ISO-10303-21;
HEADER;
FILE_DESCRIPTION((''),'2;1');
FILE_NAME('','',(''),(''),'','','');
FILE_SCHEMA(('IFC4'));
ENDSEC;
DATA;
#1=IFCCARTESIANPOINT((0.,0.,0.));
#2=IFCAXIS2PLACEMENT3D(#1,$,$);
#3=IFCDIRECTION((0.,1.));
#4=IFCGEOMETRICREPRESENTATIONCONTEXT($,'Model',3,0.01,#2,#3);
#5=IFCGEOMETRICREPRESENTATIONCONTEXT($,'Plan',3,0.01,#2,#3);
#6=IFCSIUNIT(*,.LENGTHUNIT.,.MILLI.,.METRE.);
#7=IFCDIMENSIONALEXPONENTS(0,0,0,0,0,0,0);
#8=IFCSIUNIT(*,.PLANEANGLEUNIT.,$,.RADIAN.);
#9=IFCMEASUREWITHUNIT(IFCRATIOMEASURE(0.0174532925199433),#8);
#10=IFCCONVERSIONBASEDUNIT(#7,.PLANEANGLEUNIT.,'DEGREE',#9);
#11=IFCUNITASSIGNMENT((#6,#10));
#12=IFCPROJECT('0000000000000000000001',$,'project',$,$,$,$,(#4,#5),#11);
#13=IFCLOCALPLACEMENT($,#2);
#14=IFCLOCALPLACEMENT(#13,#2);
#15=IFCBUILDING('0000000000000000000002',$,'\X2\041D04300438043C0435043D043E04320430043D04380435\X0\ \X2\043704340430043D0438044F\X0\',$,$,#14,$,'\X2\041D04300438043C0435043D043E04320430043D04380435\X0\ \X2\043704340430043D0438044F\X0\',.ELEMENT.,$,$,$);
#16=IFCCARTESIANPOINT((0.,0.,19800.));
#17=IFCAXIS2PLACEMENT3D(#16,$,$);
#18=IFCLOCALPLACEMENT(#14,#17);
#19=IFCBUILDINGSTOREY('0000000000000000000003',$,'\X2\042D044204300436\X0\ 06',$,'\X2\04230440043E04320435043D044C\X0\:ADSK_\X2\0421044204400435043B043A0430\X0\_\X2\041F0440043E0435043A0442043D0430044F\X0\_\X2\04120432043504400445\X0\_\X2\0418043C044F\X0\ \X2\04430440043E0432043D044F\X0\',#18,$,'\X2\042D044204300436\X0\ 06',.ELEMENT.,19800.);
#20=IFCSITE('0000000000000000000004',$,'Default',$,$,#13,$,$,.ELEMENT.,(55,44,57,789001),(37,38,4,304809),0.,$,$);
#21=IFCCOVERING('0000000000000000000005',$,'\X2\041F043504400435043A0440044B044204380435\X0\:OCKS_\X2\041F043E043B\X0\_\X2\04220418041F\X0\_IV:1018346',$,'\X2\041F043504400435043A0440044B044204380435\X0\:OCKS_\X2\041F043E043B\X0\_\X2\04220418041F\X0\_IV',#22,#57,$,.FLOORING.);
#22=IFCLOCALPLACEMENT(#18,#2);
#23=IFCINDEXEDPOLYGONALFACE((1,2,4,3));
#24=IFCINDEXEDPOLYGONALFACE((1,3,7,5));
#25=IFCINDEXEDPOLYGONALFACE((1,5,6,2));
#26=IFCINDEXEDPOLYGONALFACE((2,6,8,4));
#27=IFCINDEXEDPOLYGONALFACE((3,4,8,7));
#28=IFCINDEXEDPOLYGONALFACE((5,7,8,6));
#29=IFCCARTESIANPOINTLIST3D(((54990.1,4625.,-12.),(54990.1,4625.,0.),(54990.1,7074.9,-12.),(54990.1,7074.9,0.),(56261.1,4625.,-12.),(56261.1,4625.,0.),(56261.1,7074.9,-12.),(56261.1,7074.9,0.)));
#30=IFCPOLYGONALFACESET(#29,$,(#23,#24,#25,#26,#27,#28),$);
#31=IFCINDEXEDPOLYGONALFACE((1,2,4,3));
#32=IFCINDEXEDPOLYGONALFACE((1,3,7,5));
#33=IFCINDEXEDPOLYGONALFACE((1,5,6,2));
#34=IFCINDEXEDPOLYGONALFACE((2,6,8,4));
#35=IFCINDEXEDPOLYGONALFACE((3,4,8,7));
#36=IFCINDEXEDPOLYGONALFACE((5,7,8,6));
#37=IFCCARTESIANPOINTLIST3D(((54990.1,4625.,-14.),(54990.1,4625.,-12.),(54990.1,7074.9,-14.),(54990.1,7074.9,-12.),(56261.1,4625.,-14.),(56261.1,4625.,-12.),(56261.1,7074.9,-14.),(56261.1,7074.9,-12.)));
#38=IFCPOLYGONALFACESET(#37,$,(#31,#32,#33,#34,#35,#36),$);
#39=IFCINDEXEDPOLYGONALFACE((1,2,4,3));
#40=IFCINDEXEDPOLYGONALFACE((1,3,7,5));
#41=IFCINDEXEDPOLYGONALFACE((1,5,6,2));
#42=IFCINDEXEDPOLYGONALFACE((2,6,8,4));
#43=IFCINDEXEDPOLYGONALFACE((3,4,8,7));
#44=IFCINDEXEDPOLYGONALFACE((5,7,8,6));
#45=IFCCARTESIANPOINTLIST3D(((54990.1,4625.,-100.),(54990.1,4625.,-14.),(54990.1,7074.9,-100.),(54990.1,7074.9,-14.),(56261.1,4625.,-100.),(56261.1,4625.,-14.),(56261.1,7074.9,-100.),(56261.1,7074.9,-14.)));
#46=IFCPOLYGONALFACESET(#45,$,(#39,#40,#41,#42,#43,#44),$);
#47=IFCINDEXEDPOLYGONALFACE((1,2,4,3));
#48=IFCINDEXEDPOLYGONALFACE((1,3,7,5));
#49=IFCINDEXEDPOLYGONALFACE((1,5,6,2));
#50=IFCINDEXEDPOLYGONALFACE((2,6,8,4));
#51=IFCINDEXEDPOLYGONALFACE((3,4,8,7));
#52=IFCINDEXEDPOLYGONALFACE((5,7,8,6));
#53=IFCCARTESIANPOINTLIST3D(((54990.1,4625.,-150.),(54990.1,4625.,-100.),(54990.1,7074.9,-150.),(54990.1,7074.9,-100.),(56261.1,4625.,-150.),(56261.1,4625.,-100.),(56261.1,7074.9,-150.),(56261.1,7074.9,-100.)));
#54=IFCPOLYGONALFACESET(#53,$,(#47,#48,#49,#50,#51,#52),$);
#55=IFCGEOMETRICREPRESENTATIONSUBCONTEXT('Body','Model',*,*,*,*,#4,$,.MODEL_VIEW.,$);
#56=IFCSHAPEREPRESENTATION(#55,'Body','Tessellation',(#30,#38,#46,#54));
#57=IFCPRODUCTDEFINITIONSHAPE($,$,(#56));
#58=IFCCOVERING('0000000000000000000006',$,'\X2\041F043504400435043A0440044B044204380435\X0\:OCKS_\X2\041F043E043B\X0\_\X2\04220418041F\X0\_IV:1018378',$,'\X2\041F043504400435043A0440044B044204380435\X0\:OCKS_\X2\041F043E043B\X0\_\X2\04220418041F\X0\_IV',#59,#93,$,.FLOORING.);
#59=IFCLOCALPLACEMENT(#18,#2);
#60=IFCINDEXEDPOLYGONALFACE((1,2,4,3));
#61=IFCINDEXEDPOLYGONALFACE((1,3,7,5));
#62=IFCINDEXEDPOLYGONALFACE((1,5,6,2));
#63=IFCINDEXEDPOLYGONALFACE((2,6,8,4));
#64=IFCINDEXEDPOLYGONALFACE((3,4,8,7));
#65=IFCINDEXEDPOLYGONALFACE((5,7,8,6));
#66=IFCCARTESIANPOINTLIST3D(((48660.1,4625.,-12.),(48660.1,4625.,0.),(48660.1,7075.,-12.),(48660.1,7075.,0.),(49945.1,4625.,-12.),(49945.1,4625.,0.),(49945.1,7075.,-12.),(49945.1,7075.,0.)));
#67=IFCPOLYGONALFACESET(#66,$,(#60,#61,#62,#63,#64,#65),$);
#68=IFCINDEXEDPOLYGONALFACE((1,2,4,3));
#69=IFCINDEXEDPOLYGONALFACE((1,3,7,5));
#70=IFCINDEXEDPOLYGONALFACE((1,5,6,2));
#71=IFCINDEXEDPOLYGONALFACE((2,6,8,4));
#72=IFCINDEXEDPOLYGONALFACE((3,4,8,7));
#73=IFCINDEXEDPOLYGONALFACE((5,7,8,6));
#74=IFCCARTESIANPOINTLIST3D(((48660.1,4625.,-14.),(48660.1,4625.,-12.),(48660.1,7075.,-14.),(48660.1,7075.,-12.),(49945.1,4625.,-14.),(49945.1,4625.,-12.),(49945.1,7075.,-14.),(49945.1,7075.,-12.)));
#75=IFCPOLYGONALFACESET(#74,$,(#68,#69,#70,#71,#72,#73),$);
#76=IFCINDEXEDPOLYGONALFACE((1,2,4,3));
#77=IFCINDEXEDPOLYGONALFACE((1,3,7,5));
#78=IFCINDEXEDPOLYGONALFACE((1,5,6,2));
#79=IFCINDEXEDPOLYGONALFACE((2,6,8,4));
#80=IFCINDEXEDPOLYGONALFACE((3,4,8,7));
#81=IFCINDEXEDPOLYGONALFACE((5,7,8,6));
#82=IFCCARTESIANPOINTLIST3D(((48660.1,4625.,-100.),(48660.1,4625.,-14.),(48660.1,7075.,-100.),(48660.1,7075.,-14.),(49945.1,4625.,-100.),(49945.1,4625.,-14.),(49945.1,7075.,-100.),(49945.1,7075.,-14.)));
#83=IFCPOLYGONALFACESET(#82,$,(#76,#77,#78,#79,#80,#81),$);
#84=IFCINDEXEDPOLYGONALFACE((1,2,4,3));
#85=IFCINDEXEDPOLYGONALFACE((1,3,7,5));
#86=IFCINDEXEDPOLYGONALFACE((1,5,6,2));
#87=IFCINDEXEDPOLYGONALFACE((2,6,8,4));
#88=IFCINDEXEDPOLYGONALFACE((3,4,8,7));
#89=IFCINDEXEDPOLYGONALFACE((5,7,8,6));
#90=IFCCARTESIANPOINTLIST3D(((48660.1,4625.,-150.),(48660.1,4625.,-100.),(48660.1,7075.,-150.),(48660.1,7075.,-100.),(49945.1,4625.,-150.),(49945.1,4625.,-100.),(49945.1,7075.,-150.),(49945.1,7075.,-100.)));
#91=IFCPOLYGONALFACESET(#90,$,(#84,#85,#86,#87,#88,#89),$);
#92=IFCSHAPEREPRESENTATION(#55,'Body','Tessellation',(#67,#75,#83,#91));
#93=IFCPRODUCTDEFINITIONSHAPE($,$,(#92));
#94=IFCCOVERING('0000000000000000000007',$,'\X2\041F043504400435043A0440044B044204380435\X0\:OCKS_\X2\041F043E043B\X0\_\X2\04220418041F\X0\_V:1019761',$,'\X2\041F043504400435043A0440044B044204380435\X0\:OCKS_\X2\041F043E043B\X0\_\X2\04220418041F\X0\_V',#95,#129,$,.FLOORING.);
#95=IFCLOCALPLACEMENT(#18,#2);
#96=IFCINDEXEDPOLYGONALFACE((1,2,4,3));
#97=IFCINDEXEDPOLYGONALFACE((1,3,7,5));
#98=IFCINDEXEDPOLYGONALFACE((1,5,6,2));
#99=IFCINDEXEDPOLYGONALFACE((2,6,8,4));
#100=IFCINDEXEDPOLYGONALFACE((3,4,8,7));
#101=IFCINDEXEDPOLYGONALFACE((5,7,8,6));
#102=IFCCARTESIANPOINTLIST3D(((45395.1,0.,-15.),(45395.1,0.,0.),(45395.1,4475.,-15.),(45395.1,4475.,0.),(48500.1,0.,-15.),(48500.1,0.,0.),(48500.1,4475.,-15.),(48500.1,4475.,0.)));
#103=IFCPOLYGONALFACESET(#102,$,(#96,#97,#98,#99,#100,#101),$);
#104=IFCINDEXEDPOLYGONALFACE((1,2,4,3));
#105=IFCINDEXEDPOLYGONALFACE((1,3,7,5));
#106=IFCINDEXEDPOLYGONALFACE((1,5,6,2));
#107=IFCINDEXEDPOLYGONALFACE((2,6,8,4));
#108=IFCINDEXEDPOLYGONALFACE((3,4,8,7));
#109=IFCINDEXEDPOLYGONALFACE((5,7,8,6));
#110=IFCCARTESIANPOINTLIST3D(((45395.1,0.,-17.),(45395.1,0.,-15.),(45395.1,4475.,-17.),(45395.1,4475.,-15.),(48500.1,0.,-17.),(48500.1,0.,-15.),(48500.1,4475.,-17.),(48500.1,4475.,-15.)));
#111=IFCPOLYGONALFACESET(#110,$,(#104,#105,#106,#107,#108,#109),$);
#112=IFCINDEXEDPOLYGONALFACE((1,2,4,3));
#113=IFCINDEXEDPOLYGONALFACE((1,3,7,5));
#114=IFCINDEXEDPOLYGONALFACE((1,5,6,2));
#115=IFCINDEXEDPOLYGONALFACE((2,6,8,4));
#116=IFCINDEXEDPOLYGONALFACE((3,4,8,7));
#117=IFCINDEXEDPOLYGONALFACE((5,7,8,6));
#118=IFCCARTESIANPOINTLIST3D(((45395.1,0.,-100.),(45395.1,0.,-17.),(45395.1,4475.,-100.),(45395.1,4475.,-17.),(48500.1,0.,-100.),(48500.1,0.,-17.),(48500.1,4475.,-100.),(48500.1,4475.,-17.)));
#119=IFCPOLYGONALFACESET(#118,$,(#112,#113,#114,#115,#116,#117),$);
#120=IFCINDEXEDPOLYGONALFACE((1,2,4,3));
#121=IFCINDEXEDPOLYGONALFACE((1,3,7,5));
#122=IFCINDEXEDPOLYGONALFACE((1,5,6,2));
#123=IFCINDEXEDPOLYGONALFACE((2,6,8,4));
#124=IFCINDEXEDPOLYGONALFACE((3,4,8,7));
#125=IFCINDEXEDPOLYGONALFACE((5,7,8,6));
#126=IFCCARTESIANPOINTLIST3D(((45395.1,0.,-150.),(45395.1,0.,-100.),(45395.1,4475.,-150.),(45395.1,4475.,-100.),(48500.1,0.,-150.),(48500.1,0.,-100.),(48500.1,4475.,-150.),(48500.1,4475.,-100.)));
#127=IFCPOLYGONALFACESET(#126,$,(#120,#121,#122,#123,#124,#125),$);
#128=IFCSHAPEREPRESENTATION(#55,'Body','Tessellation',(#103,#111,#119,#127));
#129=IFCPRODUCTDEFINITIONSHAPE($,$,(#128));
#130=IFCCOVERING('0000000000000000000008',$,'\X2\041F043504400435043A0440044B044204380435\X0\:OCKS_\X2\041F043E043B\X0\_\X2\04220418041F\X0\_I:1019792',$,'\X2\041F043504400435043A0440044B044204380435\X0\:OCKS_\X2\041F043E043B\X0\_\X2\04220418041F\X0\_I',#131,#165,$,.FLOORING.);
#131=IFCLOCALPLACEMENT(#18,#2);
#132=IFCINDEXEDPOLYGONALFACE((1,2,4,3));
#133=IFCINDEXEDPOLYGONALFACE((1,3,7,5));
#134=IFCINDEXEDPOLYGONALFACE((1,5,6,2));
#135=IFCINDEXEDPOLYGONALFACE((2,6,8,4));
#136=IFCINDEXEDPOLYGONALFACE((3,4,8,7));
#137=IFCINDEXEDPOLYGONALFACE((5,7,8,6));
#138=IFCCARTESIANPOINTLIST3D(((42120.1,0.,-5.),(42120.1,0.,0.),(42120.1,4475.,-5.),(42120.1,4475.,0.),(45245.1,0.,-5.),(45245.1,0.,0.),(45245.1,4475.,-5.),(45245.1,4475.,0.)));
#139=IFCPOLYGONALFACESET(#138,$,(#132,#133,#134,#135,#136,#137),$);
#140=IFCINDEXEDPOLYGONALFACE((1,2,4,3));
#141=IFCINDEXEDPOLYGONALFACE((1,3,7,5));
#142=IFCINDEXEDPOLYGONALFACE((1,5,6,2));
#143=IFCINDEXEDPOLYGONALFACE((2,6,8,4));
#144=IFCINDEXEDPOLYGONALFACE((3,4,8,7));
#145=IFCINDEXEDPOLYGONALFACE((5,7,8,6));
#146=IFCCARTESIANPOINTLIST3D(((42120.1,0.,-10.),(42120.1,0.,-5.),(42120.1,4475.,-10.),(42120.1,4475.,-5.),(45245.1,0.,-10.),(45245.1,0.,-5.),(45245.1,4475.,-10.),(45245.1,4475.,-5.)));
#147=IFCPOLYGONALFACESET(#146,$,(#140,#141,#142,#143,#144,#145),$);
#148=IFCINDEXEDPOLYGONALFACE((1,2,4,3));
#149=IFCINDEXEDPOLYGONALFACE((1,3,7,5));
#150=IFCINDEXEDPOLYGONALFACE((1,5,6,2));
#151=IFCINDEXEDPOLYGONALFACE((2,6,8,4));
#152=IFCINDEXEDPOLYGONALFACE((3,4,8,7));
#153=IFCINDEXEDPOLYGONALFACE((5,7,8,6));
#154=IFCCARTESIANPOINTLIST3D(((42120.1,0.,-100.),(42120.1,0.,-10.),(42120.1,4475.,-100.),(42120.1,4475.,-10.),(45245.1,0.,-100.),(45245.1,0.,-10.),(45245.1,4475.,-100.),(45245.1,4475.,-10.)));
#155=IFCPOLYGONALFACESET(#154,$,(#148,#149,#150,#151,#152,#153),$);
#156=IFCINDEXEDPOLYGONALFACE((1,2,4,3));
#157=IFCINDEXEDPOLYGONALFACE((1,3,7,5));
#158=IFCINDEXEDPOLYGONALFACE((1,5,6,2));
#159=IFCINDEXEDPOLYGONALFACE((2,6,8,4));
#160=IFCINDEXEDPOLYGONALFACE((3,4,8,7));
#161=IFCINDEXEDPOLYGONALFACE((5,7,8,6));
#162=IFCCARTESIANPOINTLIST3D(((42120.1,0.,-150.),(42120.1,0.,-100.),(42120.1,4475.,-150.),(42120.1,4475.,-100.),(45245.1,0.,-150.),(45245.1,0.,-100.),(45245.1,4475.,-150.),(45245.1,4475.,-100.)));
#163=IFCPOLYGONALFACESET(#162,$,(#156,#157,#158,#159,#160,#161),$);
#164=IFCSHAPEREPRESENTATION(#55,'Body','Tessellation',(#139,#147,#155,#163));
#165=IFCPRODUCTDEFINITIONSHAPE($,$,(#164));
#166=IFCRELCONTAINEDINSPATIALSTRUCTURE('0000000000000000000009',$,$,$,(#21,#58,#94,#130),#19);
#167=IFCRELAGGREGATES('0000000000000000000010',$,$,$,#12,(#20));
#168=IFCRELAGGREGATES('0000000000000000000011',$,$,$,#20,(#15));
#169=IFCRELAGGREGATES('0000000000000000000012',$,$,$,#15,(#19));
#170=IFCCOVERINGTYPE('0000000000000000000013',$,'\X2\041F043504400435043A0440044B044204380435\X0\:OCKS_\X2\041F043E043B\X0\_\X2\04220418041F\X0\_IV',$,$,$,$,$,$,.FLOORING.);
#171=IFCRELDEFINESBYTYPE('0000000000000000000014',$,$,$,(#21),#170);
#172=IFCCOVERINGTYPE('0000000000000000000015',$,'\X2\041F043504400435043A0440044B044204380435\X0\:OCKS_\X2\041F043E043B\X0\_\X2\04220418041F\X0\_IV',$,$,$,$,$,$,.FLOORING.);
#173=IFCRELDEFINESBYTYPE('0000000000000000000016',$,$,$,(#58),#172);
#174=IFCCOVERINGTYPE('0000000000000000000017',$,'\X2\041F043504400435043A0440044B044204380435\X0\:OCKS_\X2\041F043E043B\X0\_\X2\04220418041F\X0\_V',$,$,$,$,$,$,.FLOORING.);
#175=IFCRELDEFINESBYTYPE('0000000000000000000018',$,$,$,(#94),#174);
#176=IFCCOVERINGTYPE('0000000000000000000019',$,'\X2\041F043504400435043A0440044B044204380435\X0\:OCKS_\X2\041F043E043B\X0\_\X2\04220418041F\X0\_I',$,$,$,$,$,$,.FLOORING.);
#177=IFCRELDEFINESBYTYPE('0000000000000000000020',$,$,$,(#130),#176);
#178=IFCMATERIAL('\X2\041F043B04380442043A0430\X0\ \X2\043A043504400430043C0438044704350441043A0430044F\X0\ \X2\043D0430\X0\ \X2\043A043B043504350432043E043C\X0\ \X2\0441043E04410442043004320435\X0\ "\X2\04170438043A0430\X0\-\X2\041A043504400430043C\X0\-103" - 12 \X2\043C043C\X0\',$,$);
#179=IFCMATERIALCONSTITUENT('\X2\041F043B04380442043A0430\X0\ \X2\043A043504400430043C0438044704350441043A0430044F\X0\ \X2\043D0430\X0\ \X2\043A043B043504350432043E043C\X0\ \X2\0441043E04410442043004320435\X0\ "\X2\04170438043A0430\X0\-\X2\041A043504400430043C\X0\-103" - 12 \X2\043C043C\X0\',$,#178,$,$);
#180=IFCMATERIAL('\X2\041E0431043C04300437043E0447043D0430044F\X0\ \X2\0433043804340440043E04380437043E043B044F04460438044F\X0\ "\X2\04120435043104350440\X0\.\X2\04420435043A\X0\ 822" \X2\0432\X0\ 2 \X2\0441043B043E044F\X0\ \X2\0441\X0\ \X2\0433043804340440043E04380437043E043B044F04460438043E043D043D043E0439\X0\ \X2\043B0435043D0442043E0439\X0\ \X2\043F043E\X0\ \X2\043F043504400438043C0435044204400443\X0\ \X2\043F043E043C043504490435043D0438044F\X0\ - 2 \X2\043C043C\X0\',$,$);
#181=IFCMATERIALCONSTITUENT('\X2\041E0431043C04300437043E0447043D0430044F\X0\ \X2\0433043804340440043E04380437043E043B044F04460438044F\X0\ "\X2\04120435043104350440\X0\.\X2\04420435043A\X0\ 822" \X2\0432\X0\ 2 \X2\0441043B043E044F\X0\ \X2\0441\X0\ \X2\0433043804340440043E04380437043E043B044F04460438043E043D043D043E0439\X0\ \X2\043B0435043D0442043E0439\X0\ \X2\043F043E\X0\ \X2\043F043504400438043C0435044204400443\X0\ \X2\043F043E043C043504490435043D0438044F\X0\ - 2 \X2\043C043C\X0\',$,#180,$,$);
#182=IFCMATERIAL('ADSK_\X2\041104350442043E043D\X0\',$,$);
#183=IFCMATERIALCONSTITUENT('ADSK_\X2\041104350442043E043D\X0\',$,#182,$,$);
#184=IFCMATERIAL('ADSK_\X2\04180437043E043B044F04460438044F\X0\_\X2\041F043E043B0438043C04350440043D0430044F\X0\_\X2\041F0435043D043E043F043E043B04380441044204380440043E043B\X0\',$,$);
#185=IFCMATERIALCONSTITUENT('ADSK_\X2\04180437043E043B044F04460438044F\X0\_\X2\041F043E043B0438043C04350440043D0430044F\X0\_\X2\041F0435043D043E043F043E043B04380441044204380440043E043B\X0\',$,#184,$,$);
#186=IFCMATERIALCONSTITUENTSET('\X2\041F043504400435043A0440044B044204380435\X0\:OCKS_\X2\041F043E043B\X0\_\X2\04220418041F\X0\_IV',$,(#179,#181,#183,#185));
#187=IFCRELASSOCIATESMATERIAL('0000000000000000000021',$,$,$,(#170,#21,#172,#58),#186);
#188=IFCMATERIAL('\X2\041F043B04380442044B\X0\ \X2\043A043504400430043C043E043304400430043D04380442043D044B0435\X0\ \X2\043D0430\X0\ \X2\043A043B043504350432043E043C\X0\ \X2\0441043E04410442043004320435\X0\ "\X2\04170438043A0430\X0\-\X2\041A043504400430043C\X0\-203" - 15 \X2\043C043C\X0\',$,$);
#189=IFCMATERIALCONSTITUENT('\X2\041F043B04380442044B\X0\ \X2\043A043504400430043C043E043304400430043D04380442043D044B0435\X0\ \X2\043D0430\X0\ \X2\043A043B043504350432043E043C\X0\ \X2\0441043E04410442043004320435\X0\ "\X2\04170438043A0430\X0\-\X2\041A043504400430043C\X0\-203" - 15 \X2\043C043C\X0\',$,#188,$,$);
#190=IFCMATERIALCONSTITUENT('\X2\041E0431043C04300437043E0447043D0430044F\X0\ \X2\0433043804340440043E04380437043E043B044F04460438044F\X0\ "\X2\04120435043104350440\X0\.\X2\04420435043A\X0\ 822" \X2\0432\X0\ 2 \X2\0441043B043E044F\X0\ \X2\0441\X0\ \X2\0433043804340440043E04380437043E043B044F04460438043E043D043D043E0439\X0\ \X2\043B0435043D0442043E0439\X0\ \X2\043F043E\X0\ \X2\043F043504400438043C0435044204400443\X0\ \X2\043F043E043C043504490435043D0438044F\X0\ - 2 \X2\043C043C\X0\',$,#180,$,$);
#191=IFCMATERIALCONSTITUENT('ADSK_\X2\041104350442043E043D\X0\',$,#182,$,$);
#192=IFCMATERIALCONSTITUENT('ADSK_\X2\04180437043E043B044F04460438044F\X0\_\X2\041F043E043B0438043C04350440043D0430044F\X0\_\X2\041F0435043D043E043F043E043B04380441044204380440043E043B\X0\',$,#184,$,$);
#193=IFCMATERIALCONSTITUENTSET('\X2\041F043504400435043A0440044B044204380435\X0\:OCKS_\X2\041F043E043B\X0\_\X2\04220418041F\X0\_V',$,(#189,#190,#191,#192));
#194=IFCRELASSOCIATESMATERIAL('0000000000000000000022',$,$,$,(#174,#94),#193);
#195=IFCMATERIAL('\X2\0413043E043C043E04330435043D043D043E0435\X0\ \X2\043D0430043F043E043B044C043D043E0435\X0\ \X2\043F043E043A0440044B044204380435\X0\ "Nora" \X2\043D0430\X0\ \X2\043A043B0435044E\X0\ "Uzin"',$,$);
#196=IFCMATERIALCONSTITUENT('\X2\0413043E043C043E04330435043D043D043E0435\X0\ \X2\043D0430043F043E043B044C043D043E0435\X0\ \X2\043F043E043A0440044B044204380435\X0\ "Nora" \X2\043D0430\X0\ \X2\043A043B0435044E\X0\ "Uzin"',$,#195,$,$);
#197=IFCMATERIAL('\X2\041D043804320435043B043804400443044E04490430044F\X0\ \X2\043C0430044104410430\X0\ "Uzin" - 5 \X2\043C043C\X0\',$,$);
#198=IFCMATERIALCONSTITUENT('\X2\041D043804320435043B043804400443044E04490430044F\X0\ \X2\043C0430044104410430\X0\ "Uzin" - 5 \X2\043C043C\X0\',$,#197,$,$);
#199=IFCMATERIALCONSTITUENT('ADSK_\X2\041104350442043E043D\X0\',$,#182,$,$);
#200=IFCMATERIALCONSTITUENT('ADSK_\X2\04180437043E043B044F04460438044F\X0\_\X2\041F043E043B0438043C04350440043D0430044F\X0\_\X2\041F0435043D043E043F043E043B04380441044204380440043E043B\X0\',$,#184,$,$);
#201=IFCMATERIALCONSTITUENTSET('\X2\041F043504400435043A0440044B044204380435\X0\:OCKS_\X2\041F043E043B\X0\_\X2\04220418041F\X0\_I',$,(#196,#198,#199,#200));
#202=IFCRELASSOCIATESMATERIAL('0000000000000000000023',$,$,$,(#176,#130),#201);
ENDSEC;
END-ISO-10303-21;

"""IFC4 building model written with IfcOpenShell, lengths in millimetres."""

from ifc_helpers import new_model, entity, si_unit, converted_unit, direction, frame, origin, place, context, subcontext, project, spatial, indexed_curve, outline, extrude, material, constituent, constituent_set, type_object, element, save


model = new_model("IFC4")

# Units and contexts
model_context = context("Model", 3, precision=0.01, world=origin(), true_north=direction((0.0, 1.0)))
plan_context = context("Plan", 3, precision=0.01, world=origin(), true_north=direction((0.0, 1.0)))
body_context = subcontext(model_context, "Body", "Model", "MODEL_VIEW")
ifc_project = project(units=[si_unit("LENGTHUNIT", "METRE", prefix="MILLI"), converted_unit("PLANEANGLEUNIT", "DEGREE", entity("IfcRatioMeasure", 0.0174532925199433), si_unit("PLANEANGLEUNIT", "RADIAN"), dimensions=[0, 0, 0, 0, 0, 0, 0])], contexts=[model_context, plan_context])

# Site, building, storey
site_placement = place(None, frame((0.0, 0.0, 0.0)))
site = spatial("IfcSite", under=ifc_project, at=site_placement, Name="Default", CompositionType="ELEMENT", RefLatitude=(55, 44, 57, 789001), RefLongitude=(37, 38, 4, 304809), RefElevation=0.0)
building_placement = place(site_placement, origin())
building = spatial("IfcBuilding", under=site, at=building_placement, Name="Наименование здания", LongName="Наименование здания", CompositionType="ELEMENT")
storey_placement = place(building_placement, frame((0.0, 0.0, 19800.0)))
storey = spatial("IfcBuildingStorey", under=building, at=storey_placement, Name="Этаж 06", ObjectType="Уровень:ADSK_Стрелка_Проектная_Вверх_Имя уровня", LongName="Этаж 06", CompositionType="ELEMENT", Elevation=19800.0)

# Coverings
ifc_material_1 = material(Name="Плиты керамогранитные на клеевом составе \"Зика-Керам-203\" - 15 мм")
ifc_constituent_1 = constituent(ifc_material_1, Name="Плиты керамогранитные на клеевом составе \"Зика-Керам-203\" - 15 мм")
ifc_material_2 = material(Name="Обмазочная гидроизоляция \"Вебер.тек 822\" в 2 слоя с гидроизоляционной лентой по периметру помещения - 2 мм")
ifc_constituent_2 = constituent(ifc_material_2, Name="Обмазочная гидроизоляция \"Вебер.тек 822\" в 2 слоя с гидроизоляционной лентой по периметру помещения - 2 мм")
ifc_material_3 = material(Name="ADSK_Бетон")
ifc_constituent_3 = constituent(ifc_material_3, Name="ADSK_Бетон")
ifc_material_4 = material(Name="ADSK_Изоляция_Полимерная_Пенополистирол")
ifc_constituent_4 = constituent(ifc_material_4, Name="ADSK_Изоляция_Полимерная_Пенополистирол")
ifc_constituent_set_1 = constituent_set(constituents=[ifc_constituent_1, ifc_constituent_2, ifc_constituent_3, ifc_constituent_4], Name="Перекрытие:OCKS_Пол_ТИП_V")
ifc_material_5 = material(Name="Гомогенное напольное покрытие \"Nora\" на клею \"Uzin\"")
ifc_constituent_5 = constituent(ifc_material_5, Name="Гомогенное напольное покрытие \"Nora\" на клею \"Uzin\"")
ifc_material_6 = material(Name="Нивелирующая масса \"Uzin\" - 5 мм")
ifc_constituent_6 = constituent(ifc_material_6, Name="Нивелирующая масса \"Uzin\" - 5 мм")
ifc_constituent_7 = constituent(ifc_material_3, Name="ADSK_Бетон")
ifc_constituent_8 = constituent(ifc_material_4, Name="ADSK_Изоляция_Полимерная_Пенополистирол")
ifc_constituent_set_2 = constituent_set(constituents=[ifc_constituent_5, ifc_constituent_6, ifc_constituent_7, ifc_constituent_8], Name="Перекрытие:OCKS_Пол_ТИП_I")
ifc_material_7 = material(Name="Плитка керамическая на клеевом составе \"Зика-Керам-103\" - 12 мм")
ifc_constituent_9 = constituent(ifc_material_7, Name="Плитка керамическая на клеевом составе \"Зика-Керам-103\" - 12 мм")
ifc_constituent_10 = constituent(ifc_material_2, Name="Обмазочная гидроизоляция \"Вебер.тек 822\" в 2 слоя с гидроизоляционной лентой по периметру помещения - 2 мм")
ifc_constituent_11 = constituent(ifc_material_3, Name="ADSK_Бетон")
ifc_constituent_12 = constituent(ifc_material_4, Name="ADSK_Изоляция_Полимерная_Пенополистирол")
ifc_constituent_set_3 = constituent_set(constituents=[ifc_constituent_9, ifc_constituent_10, ifc_constituent_11, ifc_constituent_12], Name="Перекрытие:OCKS_Пол_ТИП_IV")
covering_type_1 = type_object("IfcCoveringType", Name="Перекрытие:OCKS_Пол_ТИП_IV", PredefinedType="FLOORING", material=ifc_constituent_set_3)
covering_1_placement = place(storey_placement, origin())
element("IfcCovering", 1, at=covering_1_placement, inside=storey, type_object=covering_type_1, material=ifc_constituent_set_3, Name="Перекрытие:OCKS_Пол_ТИП_IV:1018346", ObjectType="Перекрытие:OCKS_Пол_ТИП_IV", PredefinedType="FLOORING", context=body_context, shape_type="SweptSolid", body=[
    extrude(outline(indexed_curve([(-635.5, -1225.0), (635.5, -1225.0), (635.5, 1225.0), (-635.5, 1225.0), (-635.5, -1225.0)], self_intersect=False)), frame((55625.6, 5850.0, -12.0), z_axis=(0.0, 0.0, 1.0), x_axis=(-1.0, 0.0, 0.0)), (0.0, 0.0, 1.0), 12.0),
    extrude(outline(indexed_curve([(-635.5, -1225.0), (635.5, -1225.0), (635.5, 1225.0), (-635.5, 1225.0), (-635.5, -1225.0)], self_intersect=False)), frame((55625.6, 5850.0, -14.0), z_axis=(0.0, 0.0, 1.0), x_axis=(-1.0, 0.0, 0.0)), (0.0, 0.0, 1.0), 2.0),
    extrude(outline(indexed_curve([(-635.5, -1225.0), (635.5, -1225.0), (635.5, 1225.0), (-635.5, 1225.0), (-635.5, -1225.0)], self_intersect=False)), frame((55625.6, 5850.0, -100.0), z_axis=(0.0, 0.0, 1.0), x_axis=(-1.0, 0.0, 0.0)), (0.0, 0.0, 1.0), 86.0),
    extrude(outline(indexed_curve([(-635.5, -1225.0), (635.5, -1225.0), (635.5, 1225.0), (-635.5, 1225.0), (-635.5, -1225.0)], self_intersect=False)), frame((55625.6, 5850.0, -150.0), z_axis=(0.0, 0.0, 1.0), x_axis=(-1.0, 0.0, 0.0)), (0.0, 0.0, 1.0), 50.0),
])
covering_type_2 = type_object("IfcCoveringType", Name="Перекрытие:OCKS_Пол_ТИП_IV", PredefinedType="FLOORING", material=ifc_constituent_set_3)
covering_2_placement = place(storey_placement, origin())
element("IfcCovering", 2, at=covering_2_placement, inside=storey, type_object=covering_type_2, material=ifc_constituent_set_3, Name="Перекрытие:OCKS_Пол_ТИП_IV:1018378", ObjectType="Перекрытие:OCKS_Пол_ТИП_IV", PredefinedType="FLOORING", context=body_context, shape_type="SweptSolid", body=[
    extrude(outline(indexed_curve([(-642.5, -1225.0), (642.5, -1225.0), (642.5, 1225.0), (-642.5, 1225.0), (-642.5, -1225.0)], self_intersect=False)), frame((49302.6, 5850.0, -12.0), z_axis=(0.0, 0.0, 1.0), x_axis=(-1.0, 0.0, 0.0)), (0.0, 0.0, 1.0), 12.0),
    extrude(outline(indexed_curve([(-642.5, -1225.0), (642.5, -1225.0), (642.5, 1225.0), (-642.5, 1225.0), (-642.5, -1225.0)], self_intersect=False)), frame((49302.6, 5850.0, -14.0), z_axis=(0.0, 0.0, 1.0), x_axis=(-1.0, 0.0, 0.0)), (0.0, 0.0, 1.0), 2.0),
    extrude(outline(indexed_curve([(-642.5, -1225.0), (642.5, -1225.0), (642.5, 1225.0), (-642.5, 1225.0), (-642.5, -1225.0)], self_intersect=False)), frame((49302.6, 5850.0, -100.0), z_axis=(0.0, 0.0, 1.0), x_axis=(-1.0, 0.0, 0.0)), (0.0, 0.0, 1.0), 86.0),
    extrude(outline(indexed_curve([(-642.5, -1225.0), (642.5, -1225.0), (642.5, 1225.0), (-642.5, 1225.0), (-642.5, -1225.0)], self_intersect=False)), frame((49302.6, 5850.0, -150.0), z_axis=(0.0, 0.0, 1.0), x_axis=(-1.0, 0.0, 0.0)), (0.0, 0.0, 1.0), 50.0),
])
covering_type_3 = type_object("IfcCoveringType", Name="Перекрытие:OCKS_Пол_ТИП_V", PredefinedType="FLOORING", material=ifc_constituent_set_1)
covering_3_placement = place(storey_placement, origin())
element("IfcCovering", 3, at=covering_3_placement, inside=storey, type_object=covering_type_3, material=ifc_constituent_set_1, Name="Перекрытие:OCKS_Пол_ТИП_V:1019761", ObjectType="Перекрытие:OCKS_Пол_ТИП_V", PredefinedType="FLOORING", context=body_context, shape_type="SweptSolid", body=[
    extrude(outline(indexed_curve([(-1552.5, -2237.5), (1552.5, -2237.5), (1552.5, 2237.5), (-1552.5, 2237.5), (-1552.5, -2237.5)], self_intersect=False)), frame((46947.6, 2237.5, -15.0), z_axis=(0.0, 0.0, 1.0), x_axis=(-1.0, 0.0, 0.0)), (0.0, 0.0, 1.0), 15.0),
    extrude(outline(indexed_curve([(-1552.5, -2237.5), (1552.5, -2237.5), (1552.5, 2237.5), (-1552.5, 2237.5), (-1552.5, -2237.5)], self_intersect=False)), frame((46947.6, 2237.5, -17.0), z_axis=(0.0, 0.0, 1.0), x_axis=(-1.0, 0.0, 0.0)), (0.0, 0.0, 1.0), 2.0),
    extrude(outline(indexed_curve([(-1552.5, -2237.5), (1552.5, -2237.5), (1552.5, 2237.5), (-1552.5, 2237.5), (-1552.5, -2237.5)], self_intersect=False)), frame((46947.6, 2237.5, -100.0), z_axis=(0.0, 0.0, 1.0), x_axis=(-1.0, 0.0, 0.0)), (0.0, 0.0, 1.0), 83.0),
    extrude(outline(indexed_curve([(-1552.5, -2237.5), (1552.5, -2237.5), (1552.5, 2237.5), (-1552.5, 2237.5), (-1552.5, -2237.5)], self_intersect=False)), frame((46947.6, 2237.5, -150.0), z_axis=(0.0, 0.0, 1.0), x_axis=(-1.0, 0.0, 0.0)), (0.0, 0.0, 1.0), 50.0),
])
covering_type_4 = type_object("IfcCoveringType", Name="Перекрытие:OCKS_Пол_ТИП_I", PredefinedType="FLOORING", material=ifc_constituent_set_2)
covering_4_placement = place(storey_placement, origin())
element("IfcCovering", 4, at=covering_4_placement, inside=storey, type_object=covering_type_4, material=ifc_constituent_set_2, Name="Перекрытие:OCKS_Пол_ТИП_I:1019792", ObjectType="Перекрытие:OCKS_Пол_ТИП_I", PredefinedType="FLOORING", context=body_context, shape_type="SweptSolid", body=[
    extrude(outline(indexed_curve([(-1562.5, -2237.5), (1562.5, -2237.5), (1562.5, 2237.5), (-1562.5, 2237.5), (-1562.5, -2237.5)], self_intersect=False)), frame((43682.6, 2237.5, -5.0), z_axis=(0.0, 0.0, 1.0), x_axis=(-1.0, 0.0, 0.0)), (0.0, 0.0, 1.0), 5.0),
    extrude(outline(indexed_curve([(-1562.5, -2237.5), (1562.5, -2237.5), (1562.5, 2237.5), (-1562.5, 2237.5), (-1562.5, -2237.5)], self_intersect=False)), frame((43682.6, 2237.5, -10.0), z_axis=(0.0, 0.0, 1.0), x_axis=(-1.0, 0.0, 0.0)), (0.0, 0.0, 1.0), 5.0),
    extrude(outline(indexed_curve([(-1562.5, -2237.5), (1562.5, -2237.5), (1562.5, 2237.5), (-1562.5, 2237.5), (-1562.5, -2237.5)], self_intersect=False)), frame((43682.6, 2237.5, -100.0), z_axis=(0.0, 0.0, 1.0), x_axis=(-1.0, 0.0, 0.0)), (0.0, 0.0, 1.0), 90.0),
    extrude(outline(indexed_curve([(-1562.5, -2237.5), (1562.5, -2237.5), (1562.5, 2237.5), (-1562.5, 2237.5), (-1562.5, -2237.5)], self_intersect=False)), frame((43682.6, 2237.5, -150.0), z_axis=(0.0, 0.0, 1.0), x_axis=(-1.0, 0.0, 0.0)), (0.0, 0.0, 1.0), 50.0),
])

save(model, "model.ifc")
